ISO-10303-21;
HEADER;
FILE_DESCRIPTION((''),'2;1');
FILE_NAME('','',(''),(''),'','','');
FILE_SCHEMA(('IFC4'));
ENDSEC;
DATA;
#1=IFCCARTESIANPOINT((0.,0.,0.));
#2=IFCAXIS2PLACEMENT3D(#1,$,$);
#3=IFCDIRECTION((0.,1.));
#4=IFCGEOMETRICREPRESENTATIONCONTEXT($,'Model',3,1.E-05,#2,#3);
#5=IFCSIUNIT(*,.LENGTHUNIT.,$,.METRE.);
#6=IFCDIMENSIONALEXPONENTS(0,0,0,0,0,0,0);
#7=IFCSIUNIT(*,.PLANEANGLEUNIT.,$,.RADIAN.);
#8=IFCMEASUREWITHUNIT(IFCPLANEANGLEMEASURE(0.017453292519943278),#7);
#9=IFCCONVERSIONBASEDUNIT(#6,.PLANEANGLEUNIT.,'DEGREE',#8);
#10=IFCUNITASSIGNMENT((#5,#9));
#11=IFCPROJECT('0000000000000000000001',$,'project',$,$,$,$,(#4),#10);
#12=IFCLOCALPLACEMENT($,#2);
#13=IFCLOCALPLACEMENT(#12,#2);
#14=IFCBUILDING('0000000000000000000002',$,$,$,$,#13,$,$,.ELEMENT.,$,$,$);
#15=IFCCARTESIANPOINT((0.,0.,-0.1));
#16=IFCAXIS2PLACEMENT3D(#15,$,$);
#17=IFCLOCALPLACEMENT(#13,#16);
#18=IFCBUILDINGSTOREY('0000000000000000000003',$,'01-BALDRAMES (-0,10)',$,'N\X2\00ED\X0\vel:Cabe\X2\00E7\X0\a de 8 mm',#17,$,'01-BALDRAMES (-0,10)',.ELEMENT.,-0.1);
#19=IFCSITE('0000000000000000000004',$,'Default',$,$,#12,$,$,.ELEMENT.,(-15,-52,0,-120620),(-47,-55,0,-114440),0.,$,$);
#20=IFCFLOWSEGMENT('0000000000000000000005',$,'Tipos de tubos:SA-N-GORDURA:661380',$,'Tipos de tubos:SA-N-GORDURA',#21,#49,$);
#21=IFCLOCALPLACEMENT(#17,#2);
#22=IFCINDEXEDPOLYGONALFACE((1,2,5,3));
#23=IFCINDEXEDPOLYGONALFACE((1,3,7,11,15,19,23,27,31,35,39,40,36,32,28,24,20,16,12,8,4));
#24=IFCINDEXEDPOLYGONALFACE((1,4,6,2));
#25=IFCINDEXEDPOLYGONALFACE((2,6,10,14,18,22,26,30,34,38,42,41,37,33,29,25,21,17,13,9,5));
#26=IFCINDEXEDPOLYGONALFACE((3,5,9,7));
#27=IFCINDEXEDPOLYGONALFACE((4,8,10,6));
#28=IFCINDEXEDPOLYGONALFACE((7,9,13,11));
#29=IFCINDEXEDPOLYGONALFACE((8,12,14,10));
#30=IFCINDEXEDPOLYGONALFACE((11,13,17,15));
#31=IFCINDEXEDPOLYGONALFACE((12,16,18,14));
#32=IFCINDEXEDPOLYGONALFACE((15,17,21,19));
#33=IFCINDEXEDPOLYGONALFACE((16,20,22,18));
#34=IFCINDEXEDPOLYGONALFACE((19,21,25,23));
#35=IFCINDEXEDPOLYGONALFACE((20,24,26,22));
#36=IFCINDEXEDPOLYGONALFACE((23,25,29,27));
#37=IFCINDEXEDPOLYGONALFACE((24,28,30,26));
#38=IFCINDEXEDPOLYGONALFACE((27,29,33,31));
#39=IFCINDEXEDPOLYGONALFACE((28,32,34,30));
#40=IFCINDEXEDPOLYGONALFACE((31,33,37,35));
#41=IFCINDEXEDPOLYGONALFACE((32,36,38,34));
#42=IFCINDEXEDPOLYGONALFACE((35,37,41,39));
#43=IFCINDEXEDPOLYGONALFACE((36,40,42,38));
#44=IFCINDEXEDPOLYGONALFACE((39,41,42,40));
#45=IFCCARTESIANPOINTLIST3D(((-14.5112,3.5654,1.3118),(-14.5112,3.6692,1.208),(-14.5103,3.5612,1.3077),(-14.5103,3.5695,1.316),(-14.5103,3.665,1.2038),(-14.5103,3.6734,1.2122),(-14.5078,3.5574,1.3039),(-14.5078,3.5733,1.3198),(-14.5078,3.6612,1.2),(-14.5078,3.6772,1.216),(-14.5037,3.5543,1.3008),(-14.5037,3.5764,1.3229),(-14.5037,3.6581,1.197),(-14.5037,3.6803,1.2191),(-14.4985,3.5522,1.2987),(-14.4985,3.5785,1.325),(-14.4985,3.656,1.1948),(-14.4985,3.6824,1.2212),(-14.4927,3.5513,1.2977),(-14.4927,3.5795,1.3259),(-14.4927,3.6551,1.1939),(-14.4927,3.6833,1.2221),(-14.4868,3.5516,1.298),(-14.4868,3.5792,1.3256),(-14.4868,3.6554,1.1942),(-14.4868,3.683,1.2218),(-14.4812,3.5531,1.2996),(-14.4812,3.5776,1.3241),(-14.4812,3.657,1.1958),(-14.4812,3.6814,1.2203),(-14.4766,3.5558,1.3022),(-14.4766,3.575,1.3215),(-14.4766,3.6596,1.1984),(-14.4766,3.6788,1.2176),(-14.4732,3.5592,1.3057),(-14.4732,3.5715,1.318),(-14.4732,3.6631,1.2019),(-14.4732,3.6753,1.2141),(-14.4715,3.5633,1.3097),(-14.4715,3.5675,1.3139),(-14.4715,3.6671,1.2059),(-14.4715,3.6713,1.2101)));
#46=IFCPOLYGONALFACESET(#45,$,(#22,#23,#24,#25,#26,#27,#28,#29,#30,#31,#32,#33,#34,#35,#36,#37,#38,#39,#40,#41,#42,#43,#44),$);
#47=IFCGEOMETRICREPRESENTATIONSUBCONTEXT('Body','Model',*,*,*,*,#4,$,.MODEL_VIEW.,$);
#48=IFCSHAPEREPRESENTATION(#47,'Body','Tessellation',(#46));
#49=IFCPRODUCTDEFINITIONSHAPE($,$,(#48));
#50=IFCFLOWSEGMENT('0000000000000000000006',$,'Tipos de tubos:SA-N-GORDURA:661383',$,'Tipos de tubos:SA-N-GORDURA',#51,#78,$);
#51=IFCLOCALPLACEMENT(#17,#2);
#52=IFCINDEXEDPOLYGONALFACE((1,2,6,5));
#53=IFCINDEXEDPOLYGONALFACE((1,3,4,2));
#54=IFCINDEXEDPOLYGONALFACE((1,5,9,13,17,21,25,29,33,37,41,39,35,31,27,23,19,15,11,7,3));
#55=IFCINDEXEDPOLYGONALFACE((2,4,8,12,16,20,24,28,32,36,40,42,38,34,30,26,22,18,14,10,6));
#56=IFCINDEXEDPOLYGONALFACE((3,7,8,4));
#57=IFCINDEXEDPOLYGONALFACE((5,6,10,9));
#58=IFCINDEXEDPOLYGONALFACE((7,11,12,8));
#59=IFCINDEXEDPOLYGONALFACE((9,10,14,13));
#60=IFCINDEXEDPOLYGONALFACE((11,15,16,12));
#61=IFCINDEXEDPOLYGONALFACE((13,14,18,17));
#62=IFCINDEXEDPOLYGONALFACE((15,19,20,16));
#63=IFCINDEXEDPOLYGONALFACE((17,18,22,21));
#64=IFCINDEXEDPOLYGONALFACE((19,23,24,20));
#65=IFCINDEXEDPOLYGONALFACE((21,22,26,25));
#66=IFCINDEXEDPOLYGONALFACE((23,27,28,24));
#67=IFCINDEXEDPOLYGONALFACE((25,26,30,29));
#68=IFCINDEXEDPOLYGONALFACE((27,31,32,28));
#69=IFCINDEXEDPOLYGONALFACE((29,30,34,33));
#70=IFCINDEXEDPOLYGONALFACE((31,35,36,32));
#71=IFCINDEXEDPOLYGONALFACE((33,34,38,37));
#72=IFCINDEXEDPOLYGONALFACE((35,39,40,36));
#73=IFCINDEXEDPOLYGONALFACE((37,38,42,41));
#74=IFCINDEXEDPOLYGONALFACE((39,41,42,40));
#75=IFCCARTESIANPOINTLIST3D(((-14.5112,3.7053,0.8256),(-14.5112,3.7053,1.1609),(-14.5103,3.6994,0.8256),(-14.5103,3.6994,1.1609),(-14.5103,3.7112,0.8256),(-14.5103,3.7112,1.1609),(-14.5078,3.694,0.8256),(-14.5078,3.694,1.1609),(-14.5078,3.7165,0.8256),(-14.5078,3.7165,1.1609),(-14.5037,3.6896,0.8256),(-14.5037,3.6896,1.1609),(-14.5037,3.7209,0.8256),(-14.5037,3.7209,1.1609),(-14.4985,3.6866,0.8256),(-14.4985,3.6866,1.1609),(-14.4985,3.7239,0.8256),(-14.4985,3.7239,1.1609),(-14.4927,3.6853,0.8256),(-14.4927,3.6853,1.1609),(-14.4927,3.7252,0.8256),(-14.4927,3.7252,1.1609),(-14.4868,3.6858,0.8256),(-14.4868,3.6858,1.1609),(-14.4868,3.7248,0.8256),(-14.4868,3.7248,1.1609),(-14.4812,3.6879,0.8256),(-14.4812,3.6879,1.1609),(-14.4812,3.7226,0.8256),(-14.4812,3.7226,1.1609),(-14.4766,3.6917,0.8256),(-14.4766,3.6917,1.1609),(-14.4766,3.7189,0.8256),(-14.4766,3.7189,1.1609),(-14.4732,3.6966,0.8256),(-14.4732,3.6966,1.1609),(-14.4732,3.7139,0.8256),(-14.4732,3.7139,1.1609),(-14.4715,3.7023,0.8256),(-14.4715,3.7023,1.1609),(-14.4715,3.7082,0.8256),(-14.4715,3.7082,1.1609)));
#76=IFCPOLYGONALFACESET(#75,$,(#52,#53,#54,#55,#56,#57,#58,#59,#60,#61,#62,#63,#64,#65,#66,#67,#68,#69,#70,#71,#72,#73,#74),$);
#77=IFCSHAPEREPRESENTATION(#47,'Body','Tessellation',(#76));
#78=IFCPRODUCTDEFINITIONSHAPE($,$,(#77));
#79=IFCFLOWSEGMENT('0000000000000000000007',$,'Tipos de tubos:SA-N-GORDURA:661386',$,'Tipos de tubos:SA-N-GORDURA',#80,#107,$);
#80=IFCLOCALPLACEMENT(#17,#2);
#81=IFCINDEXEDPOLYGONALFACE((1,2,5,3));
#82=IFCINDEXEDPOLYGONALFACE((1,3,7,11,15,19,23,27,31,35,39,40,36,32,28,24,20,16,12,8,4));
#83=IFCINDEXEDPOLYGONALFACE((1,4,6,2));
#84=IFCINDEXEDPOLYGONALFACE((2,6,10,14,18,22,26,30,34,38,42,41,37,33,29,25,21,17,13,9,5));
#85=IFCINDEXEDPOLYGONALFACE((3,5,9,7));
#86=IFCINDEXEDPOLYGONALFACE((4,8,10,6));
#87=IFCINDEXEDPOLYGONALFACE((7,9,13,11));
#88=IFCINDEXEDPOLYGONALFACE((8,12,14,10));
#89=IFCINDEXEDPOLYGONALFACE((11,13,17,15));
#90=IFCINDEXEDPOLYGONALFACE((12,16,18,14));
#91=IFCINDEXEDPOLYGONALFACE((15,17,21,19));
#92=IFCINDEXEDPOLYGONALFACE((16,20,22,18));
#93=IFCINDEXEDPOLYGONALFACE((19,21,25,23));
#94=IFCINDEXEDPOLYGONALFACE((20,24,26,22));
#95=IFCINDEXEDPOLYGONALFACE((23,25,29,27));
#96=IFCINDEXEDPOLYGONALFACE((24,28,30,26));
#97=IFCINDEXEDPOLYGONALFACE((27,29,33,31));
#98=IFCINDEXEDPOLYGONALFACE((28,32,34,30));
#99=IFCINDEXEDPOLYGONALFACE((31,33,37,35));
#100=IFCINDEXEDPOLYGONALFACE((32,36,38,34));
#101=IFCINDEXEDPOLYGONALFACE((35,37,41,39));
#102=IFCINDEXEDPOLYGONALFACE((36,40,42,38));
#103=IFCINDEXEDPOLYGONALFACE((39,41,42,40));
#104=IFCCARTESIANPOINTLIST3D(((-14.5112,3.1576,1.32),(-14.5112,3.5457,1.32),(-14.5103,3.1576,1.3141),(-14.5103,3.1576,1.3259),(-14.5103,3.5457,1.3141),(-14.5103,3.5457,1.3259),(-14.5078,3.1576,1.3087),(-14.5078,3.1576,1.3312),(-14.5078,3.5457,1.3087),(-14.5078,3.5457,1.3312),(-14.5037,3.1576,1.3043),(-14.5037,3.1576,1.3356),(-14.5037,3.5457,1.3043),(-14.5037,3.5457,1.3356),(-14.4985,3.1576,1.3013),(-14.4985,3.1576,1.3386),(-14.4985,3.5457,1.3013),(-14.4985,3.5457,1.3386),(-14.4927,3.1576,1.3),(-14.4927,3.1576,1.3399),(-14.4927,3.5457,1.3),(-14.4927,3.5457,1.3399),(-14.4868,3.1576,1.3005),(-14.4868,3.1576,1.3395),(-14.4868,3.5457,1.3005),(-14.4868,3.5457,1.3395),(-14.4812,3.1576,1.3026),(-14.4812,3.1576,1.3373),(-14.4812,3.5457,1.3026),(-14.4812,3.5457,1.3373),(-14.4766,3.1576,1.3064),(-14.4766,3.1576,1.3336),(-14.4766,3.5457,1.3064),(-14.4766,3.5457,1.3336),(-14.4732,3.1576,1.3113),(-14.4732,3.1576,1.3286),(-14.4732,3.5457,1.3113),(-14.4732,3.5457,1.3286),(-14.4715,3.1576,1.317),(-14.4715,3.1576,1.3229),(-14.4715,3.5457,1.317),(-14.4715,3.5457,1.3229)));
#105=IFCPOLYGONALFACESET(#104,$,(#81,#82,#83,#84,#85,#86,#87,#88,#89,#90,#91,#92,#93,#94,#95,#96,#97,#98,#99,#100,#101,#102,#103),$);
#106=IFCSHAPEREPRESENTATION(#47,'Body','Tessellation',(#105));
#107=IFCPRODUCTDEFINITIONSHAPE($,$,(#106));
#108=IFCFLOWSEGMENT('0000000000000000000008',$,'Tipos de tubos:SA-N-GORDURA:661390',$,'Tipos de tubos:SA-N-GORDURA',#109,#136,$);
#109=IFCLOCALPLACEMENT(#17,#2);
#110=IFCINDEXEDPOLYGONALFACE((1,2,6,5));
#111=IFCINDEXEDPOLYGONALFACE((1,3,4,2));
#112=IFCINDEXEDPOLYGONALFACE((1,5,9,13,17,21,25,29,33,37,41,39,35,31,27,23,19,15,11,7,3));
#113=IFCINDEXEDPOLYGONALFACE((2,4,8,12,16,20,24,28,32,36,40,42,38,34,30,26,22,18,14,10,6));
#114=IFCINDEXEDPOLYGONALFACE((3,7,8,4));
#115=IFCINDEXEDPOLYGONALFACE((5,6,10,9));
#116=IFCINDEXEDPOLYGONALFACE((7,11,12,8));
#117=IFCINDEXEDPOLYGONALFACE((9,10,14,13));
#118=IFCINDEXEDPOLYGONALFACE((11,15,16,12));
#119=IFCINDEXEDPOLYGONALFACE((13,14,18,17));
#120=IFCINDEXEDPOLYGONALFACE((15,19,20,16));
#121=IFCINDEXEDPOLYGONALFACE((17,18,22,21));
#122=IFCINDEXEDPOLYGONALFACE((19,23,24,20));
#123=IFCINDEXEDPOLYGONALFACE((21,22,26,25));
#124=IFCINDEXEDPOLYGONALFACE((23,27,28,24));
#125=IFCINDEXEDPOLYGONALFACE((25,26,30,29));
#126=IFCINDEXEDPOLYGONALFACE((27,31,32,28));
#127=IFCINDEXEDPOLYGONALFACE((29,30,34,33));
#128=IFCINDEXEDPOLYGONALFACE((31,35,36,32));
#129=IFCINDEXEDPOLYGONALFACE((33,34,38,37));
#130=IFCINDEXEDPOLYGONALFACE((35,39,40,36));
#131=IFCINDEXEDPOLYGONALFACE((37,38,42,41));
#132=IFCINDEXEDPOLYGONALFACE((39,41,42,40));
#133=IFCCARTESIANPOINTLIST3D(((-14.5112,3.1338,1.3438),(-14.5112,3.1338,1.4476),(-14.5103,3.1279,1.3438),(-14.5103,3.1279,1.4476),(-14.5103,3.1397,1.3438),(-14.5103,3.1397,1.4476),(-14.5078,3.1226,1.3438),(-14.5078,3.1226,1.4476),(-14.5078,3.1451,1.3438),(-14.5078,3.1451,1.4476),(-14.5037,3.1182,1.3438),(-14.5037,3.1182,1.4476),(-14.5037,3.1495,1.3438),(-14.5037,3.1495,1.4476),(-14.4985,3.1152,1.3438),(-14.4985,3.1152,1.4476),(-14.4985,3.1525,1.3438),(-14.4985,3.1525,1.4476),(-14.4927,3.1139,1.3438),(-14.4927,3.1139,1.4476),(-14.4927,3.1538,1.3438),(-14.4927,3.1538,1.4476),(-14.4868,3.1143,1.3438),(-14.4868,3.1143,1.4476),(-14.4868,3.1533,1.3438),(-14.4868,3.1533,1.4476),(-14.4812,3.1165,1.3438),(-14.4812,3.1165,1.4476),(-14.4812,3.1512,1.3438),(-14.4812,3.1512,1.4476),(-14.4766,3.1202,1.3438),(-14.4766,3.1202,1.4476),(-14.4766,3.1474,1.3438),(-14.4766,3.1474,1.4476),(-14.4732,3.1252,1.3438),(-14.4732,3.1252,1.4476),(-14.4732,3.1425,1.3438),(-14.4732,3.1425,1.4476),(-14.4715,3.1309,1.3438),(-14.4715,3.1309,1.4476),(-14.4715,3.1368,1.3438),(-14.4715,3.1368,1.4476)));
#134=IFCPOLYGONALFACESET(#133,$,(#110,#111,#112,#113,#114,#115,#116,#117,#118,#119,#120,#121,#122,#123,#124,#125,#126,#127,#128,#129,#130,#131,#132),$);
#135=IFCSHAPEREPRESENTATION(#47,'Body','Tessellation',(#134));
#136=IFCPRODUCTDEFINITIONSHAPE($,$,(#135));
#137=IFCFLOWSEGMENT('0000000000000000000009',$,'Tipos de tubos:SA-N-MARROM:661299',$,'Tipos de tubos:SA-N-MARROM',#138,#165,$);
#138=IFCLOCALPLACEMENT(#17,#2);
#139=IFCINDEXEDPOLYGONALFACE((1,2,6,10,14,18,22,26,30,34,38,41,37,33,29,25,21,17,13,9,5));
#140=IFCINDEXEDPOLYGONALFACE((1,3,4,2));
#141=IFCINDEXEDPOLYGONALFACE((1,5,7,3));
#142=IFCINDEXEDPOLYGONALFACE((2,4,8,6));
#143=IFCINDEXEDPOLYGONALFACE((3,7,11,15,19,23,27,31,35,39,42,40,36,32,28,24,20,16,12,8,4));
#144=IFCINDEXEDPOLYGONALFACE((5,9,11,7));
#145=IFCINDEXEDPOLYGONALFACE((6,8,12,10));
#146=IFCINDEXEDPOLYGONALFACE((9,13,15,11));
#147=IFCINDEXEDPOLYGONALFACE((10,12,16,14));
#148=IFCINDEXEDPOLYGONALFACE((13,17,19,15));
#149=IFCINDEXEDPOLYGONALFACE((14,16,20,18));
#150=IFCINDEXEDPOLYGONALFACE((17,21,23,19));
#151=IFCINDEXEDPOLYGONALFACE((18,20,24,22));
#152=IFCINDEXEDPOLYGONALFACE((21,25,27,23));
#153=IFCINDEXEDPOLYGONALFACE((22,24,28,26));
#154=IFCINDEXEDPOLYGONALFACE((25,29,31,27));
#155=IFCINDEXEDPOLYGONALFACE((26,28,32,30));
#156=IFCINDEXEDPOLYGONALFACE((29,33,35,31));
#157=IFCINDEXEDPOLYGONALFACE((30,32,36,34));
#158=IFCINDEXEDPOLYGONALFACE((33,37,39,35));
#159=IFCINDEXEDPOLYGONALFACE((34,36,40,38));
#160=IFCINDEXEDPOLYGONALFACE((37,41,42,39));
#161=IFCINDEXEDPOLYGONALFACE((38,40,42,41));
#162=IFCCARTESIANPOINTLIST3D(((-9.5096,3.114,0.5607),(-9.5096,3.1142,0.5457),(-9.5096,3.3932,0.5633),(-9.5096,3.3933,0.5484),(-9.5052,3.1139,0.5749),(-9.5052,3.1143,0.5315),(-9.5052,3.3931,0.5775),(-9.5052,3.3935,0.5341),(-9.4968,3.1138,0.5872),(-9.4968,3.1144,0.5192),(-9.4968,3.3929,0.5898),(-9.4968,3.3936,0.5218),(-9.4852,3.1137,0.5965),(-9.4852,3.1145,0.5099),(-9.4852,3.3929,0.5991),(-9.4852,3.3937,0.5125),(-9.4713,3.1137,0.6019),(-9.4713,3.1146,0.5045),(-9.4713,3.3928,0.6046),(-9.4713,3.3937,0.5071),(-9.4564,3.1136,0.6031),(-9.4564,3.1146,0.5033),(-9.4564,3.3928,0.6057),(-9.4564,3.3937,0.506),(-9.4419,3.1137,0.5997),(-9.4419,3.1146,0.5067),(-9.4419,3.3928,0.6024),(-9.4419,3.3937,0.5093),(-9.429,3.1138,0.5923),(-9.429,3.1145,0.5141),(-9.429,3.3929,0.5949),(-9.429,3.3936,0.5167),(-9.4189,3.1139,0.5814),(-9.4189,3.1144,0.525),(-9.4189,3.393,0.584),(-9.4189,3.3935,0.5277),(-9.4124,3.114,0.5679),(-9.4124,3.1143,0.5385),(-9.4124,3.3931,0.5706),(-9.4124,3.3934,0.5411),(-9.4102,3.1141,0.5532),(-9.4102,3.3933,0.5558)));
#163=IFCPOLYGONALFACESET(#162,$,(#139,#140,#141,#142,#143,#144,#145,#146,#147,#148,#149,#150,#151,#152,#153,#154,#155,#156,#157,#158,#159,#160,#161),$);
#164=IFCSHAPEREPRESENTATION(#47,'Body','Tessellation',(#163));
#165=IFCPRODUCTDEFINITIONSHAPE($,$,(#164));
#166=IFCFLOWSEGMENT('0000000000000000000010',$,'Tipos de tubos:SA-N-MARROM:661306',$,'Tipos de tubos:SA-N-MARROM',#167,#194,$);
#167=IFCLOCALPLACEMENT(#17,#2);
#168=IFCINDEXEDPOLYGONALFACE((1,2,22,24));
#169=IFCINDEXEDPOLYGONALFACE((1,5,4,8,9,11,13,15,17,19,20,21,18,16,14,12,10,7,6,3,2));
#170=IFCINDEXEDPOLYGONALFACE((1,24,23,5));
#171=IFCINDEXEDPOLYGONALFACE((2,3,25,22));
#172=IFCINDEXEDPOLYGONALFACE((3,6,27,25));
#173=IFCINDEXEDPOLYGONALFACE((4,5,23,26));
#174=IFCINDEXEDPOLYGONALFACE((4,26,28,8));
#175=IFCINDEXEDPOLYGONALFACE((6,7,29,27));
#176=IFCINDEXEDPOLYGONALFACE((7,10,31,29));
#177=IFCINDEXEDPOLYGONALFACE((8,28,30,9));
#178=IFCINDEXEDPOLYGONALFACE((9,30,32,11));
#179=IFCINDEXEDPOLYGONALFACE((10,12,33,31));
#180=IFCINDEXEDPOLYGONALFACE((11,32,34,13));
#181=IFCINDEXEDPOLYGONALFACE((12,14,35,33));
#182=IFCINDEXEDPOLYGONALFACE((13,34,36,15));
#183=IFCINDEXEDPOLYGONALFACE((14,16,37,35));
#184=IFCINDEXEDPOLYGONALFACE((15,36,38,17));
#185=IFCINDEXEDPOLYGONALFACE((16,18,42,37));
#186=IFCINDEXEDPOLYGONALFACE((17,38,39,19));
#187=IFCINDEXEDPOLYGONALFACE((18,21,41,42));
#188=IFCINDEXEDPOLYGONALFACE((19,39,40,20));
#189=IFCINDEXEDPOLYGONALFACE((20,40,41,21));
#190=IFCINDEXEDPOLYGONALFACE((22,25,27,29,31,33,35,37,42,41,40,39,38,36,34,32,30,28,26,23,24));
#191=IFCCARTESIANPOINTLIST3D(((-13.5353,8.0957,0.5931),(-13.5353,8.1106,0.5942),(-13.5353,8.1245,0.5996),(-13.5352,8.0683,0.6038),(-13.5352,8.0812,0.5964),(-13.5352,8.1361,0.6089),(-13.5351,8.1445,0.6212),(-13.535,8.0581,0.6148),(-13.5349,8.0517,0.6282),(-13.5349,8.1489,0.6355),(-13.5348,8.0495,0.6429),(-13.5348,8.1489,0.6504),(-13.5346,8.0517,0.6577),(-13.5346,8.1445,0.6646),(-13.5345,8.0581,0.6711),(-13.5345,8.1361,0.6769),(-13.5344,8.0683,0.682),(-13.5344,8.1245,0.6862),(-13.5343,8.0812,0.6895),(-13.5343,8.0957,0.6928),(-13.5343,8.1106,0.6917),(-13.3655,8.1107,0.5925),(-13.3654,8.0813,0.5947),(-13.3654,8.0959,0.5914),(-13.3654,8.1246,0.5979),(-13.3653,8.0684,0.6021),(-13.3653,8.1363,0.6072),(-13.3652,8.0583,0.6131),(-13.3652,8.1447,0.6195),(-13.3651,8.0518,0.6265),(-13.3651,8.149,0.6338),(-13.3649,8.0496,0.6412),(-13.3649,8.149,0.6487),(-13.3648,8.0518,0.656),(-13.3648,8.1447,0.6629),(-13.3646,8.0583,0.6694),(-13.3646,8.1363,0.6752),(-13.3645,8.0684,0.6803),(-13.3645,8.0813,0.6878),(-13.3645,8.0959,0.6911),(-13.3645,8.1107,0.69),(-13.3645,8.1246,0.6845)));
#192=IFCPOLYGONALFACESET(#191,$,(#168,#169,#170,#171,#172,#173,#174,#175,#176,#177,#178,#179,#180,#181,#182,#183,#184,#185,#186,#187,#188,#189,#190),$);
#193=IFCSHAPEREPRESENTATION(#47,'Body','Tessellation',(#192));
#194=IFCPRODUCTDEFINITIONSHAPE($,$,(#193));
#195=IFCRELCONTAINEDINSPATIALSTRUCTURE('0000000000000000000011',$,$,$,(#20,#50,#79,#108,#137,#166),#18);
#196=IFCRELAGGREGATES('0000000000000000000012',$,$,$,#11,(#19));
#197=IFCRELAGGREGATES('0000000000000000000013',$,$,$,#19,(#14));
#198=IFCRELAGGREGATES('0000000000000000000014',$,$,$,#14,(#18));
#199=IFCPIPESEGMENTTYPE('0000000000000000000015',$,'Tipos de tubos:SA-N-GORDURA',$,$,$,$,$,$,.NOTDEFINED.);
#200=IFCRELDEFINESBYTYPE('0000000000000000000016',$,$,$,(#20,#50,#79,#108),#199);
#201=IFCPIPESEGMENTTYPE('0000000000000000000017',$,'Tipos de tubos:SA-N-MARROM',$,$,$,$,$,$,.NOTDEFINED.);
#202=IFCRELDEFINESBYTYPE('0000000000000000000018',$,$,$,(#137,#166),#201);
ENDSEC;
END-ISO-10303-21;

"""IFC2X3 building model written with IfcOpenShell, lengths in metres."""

from ifc_helpers import new_model, entity, si_unit, converted_unit, direction, frame, frame_2d, origin, origin_2d_with_axis, place, context, subcontext, project, spatial, circle, extrude, type_object, element, save


model = new_model("IFC2X3")

# Units and contexts
model_context = context("Model", 3, precision=1e-05, world=origin(), true_north=direction((0.0, 1.0)))
body_context = subcontext(model_context, "Body", "Model", "MODEL_VIEW")
ifc_project = project(units=[si_unit("LENGTHUNIT", "METRE"), converted_unit("PLANEANGLEUNIT", "DEGREE", entity("IfcPlaneAngleMeasure", 0.017453292519943278), si_unit("PLANEANGLEUNIT", "RADIAN"), dimensions=[0, 0, 0, 0, 0, 0, 0])], contexts=[model_context])

# Site, building, storey
site_placement = place(None, origin())
site = spatial("IfcSite", under=ifc_project, at=site_placement, Name="Default", CompositionType="ELEMENT", RefLatitude=(-15, -52, 0, -120620), RefLongitude=(-47, -55, 0, -114440), RefElevation=0.0)
building_placement = place(site_placement, origin())
building = spatial("IfcBuilding", under=site, at=building_placement, CompositionType="ELEMENT")
storey_placement = place(building_placement, frame((0.0, 0.0, -0.1)))
storey = spatial("IfcBuildingStorey", under=building, at=storey_placement, Name="01-BALDRAMES (-0,10)", ObjectType="Nível:Cabeça de 8 mm", LongName="01-BALDRAMES (-0,10)", CompositionType="ELEMENT", Elevation=-0.1)

# Flow segments
pipe_segment_type_1 = type_object("IfcPipeSegmentType", Name="Tipos de tubos:SA-N-GORDURA", PredefinedType="NOTDEFINED")
flow_segment_1_placement = place(storey_placement, origin())
element("IfcFlowSegment", 1, at=flow_segment_1_placement, inside=storey, type_object=pipe_segment_type_1, Name="Tipos de tubos:SA-N-GORDURA:661380", ObjectType="Tipos de tubos:SA-N-GORDURA", context=body_context, shape_type="SweptSolid", body=[
    extrude(circle(Radius=0.02, at=frame_2d((0.0, 0.0), x_axis=(1.0, 0.0))), frame((-14.4912, 3.6692, 1.208), z_axis=(0.000001, -0.707107, 0.707107), x_axis=(-1.0, -0.000001, 0.0)), (0.0, 0.0, 1.0), 0.1468),
])
flow_segment_2_placement = place(storey_placement, origin())
element("IfcFlowSegment", 2, at=flow_segment_2_placement, inside=storey, type_object=pipe_segment_type_1, Name="Tipos de tubos:SA-N-GORDURA:661383", ObjectType="Tipos de tubos:SA-N-GORDURA", context=body_context, shape_type="SweptSolid", body=[
    extrude(circle(Radius=0.02, at=origin_2d_with_axis()), frame((-14.4912, 3.7053, 0.8256), z_axis=(0.0, 0.0, 1.0), x_axis=(-1.0, 0.0, 0.0)), (0.0, 0.0, 1.0), 0.3353),
])
flow_segment_3_placement = place(storey_placement, origin())
element("IfcFlowSegment", 3, at=flow_segment_3_placement, inside=storey, type_object=pipe_segment_type_1, Name="Tipos de tubos:SA-N-GORDURA:661386", ObjectType="Tipos de tubos:SA-N-GORDURA", context=body_context, shape_type="SweptSolid", body=[
    extrude(circle(Radius=0.02, at=origin_2d_with_axis()), frame((-14.4912, 3.1576, 1.32), z_axis=(-0.000001, 1.0, 0.0), x_axis=(-1.0, -0.000001, 0.0)), (0.0, 0.0, 1.0), 0.3881),
])
flow_segment_4_placement = place(storey_placement, origin())
element("IfcFlowSegment", 4, at=flow_segment_4_placement, inside=storey, type_object=pipe_segment_type_1, Name="Tipos de tubos:SA-N-GORDURA:661390", ObjectType="Tipos de tubos:SA-N-GORDURA", context=body_context, shape_type="SweptSolid", body=[
    extrude(circle(Radius=0.02, at=origin_2d_with_axis()), frame((-14.4912, 3.1338, 1.3438), z_axis=(0.0, 0.0, 1.0), x_axis=(-1.0, 0.0, 0.0)), (0.0, 0.0, 1.0), 0.1038),
])
pipe_segment_type_2 = type_object("IfcPipeSegmentType", Name="Tipos de tubos:SA-N-MARROM", PredefinedType="NOTDEFINED")
flow_segment_5_placement = place(storey_placement, origin())
element("IfcFlowSegment", 5, at=flow_segment_5_placement, inside=storey, type_object=pipe_segment_type_2, Name="Tipos de tubos:SA-N-MARROM:661299", ObjectType="Tipos de tubos:SA-N-MARROM", context=body_context, shape_type="SweptSolid", body=[
    extrude(circle(Radius=0.05, at=origin_2d_with_axis()), frame((-9.4602, 3.1141, 0.5532), z_axis=(-0.000001, 0.999956, 0.009424), x_axis=(1.0, 0.000001, 0.0)), (0.0, 0.0, 1.0), 0.2792),
])
flow_segment_6_placement = place(storey_placement, origin())
element("IfcFlowSegment", 6, at=flow_segment_6_placement, inside=storey, type_object=pipe_segment_type_2, Name="Tipos de tubos:SA-N-MARROM:661306", ObjectType="Tipos de tubos:SA-N-MARROM", context=body_context, shape_type="SweptSolid", body=[
    extrude(circle(Radius=0.05, at=frame_2d((0.0, 0.0), x_axis=(1.0, 0.0))), frame((-13.5348, 8.0995, 0.6429), z_axis=(0.99995, 0.000866, -0.01), x_axis=(0.000866, -1.0, 0.0)), (0.0, 0.0, 1.0), 0.1699),
])

save(model, "model.ifc")
